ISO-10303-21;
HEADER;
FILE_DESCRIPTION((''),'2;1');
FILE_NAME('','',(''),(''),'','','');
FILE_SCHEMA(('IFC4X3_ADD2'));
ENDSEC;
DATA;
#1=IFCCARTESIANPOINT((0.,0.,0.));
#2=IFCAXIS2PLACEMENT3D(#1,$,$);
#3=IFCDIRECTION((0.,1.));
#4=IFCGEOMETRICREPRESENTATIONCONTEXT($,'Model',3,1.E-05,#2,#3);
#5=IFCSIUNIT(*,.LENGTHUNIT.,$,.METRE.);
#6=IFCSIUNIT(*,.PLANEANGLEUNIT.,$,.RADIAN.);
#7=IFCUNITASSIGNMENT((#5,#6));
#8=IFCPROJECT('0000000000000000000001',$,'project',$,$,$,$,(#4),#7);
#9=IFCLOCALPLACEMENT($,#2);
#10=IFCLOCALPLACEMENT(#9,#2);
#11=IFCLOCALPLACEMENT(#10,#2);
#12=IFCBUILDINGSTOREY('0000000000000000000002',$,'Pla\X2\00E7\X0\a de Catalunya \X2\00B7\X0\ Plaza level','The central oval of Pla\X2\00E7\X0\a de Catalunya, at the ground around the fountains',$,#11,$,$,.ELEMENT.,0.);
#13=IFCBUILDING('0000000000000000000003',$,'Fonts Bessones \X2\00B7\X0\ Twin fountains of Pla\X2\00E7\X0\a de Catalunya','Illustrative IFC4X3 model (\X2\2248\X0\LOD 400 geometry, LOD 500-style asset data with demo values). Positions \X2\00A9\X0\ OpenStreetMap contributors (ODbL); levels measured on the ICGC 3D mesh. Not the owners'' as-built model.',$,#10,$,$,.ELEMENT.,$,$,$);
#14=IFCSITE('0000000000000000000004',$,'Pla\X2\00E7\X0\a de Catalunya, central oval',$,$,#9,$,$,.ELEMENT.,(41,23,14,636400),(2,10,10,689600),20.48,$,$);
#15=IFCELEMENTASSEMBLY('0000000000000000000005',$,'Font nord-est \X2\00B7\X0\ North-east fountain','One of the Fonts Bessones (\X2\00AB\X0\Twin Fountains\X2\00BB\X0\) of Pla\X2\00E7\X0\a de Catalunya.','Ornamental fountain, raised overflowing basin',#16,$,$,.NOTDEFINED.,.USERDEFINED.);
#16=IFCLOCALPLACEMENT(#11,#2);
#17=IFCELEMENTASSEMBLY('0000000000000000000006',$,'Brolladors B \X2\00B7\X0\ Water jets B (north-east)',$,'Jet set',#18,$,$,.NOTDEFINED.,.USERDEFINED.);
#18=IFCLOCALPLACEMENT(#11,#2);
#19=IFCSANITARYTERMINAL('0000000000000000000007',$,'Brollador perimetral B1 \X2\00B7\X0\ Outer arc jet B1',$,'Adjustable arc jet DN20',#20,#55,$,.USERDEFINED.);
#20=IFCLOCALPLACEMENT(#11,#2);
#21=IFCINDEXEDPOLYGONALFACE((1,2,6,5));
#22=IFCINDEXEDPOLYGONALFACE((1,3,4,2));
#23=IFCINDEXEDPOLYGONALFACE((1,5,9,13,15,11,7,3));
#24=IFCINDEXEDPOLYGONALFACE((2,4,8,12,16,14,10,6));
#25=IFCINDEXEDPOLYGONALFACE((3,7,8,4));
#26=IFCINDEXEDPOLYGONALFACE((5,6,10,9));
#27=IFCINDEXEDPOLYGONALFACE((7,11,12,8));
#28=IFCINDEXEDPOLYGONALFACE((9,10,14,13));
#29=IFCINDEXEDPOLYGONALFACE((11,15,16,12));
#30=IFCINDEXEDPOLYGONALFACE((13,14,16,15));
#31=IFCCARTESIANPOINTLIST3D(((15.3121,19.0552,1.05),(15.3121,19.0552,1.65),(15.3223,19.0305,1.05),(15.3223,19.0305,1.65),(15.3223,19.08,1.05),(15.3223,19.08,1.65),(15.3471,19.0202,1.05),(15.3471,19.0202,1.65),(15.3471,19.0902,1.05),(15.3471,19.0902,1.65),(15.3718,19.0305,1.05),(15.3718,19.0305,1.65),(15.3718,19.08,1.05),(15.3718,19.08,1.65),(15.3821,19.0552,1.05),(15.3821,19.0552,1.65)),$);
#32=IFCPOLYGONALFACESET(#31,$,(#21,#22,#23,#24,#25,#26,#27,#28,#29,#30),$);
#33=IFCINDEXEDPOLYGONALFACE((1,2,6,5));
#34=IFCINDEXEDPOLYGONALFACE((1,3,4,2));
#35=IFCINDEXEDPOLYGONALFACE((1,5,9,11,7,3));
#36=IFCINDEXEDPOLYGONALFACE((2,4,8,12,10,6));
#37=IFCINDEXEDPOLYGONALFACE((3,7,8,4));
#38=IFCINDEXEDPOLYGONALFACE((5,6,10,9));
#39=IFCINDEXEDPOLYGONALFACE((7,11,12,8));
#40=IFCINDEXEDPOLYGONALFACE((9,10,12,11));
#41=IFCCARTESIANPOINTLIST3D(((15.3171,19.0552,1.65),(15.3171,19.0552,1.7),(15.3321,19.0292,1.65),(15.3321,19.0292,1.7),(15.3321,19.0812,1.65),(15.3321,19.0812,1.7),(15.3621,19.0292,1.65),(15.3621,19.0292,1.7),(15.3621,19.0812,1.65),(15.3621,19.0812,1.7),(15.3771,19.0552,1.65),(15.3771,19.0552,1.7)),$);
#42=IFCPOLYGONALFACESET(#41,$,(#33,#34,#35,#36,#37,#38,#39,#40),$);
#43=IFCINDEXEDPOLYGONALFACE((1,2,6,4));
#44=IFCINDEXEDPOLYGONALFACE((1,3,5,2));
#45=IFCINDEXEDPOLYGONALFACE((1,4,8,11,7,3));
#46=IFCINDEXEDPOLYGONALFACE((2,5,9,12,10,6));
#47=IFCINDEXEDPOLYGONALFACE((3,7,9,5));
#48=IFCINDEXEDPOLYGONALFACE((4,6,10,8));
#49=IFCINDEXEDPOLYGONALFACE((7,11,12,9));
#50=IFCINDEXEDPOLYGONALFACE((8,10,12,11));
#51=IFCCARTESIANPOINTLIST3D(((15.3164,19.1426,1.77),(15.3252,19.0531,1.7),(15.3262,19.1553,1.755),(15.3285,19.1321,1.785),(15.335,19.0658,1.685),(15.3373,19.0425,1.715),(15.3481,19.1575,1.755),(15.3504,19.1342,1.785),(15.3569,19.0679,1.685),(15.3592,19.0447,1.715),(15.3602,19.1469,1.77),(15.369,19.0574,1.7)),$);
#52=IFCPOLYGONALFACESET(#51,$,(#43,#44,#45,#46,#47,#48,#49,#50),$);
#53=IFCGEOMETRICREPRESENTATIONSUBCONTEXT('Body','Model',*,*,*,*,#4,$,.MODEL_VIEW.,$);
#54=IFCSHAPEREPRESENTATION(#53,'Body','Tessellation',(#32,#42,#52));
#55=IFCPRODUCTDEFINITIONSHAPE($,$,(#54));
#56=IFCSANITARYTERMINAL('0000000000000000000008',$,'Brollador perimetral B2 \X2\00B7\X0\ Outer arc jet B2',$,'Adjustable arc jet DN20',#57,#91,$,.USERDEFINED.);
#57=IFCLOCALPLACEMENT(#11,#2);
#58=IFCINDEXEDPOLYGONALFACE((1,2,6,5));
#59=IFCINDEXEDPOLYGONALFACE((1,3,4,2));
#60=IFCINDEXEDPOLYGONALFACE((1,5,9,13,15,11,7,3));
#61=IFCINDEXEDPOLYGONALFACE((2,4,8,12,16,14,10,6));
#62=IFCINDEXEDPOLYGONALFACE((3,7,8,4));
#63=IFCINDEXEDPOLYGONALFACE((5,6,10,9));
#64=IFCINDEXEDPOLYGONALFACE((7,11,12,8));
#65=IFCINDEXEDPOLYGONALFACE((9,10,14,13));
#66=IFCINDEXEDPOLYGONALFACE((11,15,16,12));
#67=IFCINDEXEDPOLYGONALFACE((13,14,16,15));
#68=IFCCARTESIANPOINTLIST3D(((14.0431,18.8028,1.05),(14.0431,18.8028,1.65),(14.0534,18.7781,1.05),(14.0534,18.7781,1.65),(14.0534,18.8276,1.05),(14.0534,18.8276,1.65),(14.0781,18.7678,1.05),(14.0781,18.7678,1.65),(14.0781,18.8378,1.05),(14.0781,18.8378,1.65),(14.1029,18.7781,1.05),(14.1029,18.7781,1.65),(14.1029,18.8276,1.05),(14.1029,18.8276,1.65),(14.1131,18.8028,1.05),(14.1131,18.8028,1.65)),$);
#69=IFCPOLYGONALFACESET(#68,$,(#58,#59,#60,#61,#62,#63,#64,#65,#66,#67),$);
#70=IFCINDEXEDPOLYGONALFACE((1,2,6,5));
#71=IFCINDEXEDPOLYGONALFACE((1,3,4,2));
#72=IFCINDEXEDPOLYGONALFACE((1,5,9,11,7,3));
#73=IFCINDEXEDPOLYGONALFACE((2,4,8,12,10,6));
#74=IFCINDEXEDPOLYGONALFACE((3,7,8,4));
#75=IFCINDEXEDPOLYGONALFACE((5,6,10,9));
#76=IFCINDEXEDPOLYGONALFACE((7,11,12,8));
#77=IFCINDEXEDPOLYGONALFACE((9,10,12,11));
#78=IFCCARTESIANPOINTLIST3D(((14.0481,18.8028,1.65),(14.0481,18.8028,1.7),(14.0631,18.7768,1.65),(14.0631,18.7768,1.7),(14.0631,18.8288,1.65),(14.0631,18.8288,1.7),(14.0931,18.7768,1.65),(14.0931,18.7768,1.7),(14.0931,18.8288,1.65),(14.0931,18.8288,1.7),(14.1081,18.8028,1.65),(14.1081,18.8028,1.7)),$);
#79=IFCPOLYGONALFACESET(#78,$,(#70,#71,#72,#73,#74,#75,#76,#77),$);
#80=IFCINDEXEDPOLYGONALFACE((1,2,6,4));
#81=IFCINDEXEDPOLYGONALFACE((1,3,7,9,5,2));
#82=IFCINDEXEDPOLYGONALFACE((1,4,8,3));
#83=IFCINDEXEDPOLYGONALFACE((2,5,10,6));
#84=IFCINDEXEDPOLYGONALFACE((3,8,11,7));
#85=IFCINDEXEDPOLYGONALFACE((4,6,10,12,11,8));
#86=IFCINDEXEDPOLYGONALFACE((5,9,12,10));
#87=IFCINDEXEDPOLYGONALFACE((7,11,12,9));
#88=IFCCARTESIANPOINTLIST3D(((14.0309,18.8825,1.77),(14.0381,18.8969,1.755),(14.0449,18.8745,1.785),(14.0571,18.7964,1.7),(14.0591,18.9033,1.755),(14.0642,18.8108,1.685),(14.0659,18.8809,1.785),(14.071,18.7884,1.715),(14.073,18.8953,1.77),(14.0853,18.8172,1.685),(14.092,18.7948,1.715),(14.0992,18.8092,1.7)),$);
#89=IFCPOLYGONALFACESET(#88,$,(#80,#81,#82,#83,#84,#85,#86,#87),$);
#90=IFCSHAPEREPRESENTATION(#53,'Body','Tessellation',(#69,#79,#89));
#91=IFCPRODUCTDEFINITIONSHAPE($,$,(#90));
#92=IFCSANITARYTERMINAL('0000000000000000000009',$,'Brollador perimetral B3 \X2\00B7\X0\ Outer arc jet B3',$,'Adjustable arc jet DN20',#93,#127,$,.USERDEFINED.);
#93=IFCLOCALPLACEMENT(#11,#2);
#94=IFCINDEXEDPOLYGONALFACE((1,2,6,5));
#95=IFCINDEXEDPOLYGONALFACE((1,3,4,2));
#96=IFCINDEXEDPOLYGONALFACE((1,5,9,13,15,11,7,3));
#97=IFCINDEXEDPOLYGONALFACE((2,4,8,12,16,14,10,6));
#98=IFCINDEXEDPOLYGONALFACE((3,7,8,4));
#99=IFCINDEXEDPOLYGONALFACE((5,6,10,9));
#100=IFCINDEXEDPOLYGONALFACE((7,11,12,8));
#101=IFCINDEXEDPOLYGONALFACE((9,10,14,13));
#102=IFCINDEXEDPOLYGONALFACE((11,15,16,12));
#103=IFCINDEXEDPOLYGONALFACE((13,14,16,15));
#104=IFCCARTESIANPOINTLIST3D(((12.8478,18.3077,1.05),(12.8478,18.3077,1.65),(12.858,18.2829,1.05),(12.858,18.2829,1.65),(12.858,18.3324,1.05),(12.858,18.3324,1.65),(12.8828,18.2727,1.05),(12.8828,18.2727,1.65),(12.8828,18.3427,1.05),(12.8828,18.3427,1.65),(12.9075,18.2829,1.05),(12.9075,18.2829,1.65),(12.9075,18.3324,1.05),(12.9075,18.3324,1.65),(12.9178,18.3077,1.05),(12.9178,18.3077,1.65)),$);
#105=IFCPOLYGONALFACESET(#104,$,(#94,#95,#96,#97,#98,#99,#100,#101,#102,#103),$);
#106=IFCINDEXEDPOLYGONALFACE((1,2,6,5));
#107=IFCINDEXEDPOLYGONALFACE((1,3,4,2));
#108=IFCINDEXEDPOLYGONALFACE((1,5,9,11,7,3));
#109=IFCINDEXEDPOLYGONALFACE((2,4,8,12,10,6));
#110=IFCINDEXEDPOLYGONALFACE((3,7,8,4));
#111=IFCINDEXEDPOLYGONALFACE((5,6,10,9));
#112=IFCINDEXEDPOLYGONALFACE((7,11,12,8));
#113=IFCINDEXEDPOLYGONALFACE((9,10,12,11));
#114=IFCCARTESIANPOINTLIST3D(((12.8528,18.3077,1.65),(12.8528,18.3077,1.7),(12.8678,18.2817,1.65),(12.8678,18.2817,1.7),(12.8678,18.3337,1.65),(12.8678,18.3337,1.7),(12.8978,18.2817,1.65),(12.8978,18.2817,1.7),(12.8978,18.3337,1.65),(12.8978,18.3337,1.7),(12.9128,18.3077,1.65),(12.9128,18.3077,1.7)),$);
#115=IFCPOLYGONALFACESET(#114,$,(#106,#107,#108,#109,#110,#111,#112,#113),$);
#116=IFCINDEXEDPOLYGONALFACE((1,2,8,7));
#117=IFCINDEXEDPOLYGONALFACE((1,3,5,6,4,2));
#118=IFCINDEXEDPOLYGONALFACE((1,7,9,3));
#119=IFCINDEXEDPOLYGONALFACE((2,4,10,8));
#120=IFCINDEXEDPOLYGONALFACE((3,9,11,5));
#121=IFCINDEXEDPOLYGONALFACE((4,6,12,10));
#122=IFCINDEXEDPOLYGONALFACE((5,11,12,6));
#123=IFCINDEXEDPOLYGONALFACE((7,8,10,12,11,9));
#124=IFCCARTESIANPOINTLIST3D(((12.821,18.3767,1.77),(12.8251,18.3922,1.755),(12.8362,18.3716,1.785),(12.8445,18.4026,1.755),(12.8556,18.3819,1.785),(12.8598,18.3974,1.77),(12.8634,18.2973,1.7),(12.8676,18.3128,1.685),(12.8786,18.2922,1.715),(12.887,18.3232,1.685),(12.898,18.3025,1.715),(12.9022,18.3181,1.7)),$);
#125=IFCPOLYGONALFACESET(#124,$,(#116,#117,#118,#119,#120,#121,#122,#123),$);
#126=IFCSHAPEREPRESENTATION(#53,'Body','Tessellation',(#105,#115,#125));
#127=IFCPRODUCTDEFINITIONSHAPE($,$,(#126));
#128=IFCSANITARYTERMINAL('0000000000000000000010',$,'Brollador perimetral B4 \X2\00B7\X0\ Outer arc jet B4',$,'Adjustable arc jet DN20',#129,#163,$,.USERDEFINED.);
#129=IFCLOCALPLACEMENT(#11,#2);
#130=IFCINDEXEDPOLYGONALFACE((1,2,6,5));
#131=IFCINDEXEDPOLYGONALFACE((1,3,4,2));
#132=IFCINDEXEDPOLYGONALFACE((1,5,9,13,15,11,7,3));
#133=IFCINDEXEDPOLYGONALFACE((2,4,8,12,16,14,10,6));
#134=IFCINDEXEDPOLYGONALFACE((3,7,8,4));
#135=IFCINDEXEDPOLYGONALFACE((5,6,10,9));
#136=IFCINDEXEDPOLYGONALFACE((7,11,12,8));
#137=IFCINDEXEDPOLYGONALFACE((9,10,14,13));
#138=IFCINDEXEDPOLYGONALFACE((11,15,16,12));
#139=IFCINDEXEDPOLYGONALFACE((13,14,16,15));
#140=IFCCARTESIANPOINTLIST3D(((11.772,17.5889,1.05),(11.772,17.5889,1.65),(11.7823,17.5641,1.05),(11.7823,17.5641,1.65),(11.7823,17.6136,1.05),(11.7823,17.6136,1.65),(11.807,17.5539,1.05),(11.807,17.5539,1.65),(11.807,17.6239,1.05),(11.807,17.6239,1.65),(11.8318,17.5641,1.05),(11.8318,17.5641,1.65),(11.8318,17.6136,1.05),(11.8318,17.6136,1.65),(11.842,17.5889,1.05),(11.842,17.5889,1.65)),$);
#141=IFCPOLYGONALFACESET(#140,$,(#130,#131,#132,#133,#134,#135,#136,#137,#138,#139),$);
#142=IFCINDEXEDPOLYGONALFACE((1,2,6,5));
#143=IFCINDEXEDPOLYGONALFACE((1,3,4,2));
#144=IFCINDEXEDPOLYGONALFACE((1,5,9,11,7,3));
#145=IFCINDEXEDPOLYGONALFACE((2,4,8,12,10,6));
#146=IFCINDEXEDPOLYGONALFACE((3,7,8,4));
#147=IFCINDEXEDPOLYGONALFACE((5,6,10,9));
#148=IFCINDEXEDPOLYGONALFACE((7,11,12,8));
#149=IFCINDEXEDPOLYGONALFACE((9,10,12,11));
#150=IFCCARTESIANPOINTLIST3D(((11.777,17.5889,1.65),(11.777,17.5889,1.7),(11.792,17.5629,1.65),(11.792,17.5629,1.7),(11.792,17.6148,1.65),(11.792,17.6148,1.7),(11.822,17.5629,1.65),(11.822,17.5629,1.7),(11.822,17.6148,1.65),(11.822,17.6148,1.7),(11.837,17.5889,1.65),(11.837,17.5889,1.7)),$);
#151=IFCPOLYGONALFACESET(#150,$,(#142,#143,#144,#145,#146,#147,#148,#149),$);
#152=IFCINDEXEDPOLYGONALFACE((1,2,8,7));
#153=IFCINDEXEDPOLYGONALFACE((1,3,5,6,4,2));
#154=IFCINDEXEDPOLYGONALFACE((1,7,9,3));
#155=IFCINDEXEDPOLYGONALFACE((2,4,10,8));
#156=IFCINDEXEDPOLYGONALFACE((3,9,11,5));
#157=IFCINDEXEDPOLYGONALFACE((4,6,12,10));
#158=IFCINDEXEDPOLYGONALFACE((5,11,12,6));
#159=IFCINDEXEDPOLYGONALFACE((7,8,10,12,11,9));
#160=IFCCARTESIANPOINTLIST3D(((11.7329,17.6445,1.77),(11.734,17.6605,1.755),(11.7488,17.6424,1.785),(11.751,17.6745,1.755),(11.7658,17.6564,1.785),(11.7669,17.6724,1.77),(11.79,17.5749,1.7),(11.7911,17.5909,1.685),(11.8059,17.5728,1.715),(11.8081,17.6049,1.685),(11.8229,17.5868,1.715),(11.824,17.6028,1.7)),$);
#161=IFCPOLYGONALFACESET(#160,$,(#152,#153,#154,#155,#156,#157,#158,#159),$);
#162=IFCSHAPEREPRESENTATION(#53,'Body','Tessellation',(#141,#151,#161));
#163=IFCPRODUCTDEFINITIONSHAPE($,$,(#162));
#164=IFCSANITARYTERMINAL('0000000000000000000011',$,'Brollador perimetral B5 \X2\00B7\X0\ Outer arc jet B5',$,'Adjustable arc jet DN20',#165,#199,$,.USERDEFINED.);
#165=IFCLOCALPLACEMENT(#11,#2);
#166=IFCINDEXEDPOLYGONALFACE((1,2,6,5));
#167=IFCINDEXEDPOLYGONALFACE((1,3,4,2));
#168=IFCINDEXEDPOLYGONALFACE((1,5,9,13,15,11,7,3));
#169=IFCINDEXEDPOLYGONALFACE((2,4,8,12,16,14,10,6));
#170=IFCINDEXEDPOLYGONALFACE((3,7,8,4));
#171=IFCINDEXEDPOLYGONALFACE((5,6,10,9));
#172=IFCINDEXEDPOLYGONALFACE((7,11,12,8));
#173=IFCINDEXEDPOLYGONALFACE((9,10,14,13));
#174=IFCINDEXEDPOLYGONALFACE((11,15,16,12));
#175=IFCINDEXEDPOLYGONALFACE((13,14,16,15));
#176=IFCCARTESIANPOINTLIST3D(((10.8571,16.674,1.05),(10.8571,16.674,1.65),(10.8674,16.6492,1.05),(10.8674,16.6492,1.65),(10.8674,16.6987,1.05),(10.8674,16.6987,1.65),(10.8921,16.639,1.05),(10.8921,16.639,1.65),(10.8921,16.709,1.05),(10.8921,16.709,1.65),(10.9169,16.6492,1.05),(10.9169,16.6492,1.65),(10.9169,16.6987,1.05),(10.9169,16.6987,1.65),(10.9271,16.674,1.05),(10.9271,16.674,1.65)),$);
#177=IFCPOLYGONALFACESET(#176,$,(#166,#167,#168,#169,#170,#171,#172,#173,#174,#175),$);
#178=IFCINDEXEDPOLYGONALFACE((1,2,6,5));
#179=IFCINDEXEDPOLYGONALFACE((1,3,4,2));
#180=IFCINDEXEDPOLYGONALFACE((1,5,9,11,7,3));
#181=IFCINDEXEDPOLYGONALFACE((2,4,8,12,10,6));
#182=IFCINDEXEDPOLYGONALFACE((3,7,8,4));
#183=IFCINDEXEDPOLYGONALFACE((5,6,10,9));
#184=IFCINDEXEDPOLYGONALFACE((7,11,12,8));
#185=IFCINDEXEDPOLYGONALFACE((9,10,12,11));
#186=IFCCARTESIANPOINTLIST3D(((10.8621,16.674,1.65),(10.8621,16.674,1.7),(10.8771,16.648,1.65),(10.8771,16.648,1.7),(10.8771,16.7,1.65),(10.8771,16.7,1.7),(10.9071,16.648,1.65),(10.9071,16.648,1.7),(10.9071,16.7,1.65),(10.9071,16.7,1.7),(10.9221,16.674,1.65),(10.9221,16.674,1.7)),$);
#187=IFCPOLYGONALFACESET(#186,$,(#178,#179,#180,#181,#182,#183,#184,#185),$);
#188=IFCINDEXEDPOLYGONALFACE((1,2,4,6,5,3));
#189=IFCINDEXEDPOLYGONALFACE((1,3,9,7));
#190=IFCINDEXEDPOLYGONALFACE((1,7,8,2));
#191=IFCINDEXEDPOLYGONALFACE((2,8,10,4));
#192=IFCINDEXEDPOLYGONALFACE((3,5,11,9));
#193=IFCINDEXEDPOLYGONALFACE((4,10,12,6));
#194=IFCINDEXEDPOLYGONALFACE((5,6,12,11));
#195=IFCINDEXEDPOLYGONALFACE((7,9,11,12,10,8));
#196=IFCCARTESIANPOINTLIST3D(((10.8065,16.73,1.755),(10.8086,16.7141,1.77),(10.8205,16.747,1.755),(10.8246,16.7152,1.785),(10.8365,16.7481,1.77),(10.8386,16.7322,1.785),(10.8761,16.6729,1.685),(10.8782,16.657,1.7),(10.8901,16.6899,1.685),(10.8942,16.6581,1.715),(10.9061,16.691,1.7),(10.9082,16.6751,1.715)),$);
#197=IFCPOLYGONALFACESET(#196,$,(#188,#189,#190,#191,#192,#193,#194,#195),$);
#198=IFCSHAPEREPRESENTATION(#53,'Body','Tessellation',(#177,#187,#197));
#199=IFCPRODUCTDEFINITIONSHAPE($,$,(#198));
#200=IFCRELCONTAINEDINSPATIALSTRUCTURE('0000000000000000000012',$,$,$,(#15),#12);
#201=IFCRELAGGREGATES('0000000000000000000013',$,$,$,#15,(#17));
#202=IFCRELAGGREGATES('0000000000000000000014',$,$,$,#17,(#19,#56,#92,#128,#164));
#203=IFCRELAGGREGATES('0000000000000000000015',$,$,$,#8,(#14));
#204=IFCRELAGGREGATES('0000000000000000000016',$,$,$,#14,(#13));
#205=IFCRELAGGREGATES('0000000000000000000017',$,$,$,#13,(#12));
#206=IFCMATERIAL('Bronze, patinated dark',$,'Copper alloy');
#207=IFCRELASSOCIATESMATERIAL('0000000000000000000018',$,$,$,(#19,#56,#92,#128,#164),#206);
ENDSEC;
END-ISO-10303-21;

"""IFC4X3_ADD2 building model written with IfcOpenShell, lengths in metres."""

from ifc_helpers import new_model, si_unit, direction, frame, origin, place, context, subcontext, project, spatial, polyline, outline, extrude, material, element, aggregate, save


model = new_model("IFC4X3_ADD2")

# Units and contexts
model_context = context("Model", 3, precision=1e-05, world=origin(), true_north=direction((0.0, 1.0)))
body_context = subcontext(model_context, "Body", "Model", "MODEL_VIEW")
ifc_project = project(units=[si_unit("LENGTHUNIT", "METRE"), si_unit("PLANEANGLEUNIT", "RADIAN")], contexts=[model_context])

# Site, building, storey
site_placement = place(None, origin())
site = spatial("IfcSite", under=ifc_project, at=site_placement, Name="Plaça de Catalunya, central oval", CompositionType="ELEMENT", RefLatitude=(41, 23, 14, 636400), RefLongitude=(2, 10, 10, 689600), RefElevation=20.48)
building_placement = place(site_placement, origin())
building = spatial("IfcBuilding", under=site, at=building_placement, Name="Fonts Bessones · Twin fountains of Plaça de Catalunya", Description="Illustrative IFC4X3 model (≈LOD 400 geometry, LOD 500-style asset data with demo values). Positions © OpenStreetMap contributors (ODbL); levels measured on the ICGC 3D mesh. Not the owners' as-built model.", CompositionType="ELEMENT")
storey_placement = place(building_placement, origin())
storey = spatial("IfcBuildingStorey", under=building, at=storey_placement, Name="Plaça de Catalunya · Plaza level", Description="The central oval of Plaça de Catalunya, at the ground around the fountains", CompositionType="ELEMENT", Elevation=0.0)

# Element assemblies, sanitary terminals
assembly_1_placement = place(building_placement, origin())
assembly_1 = element("IfcElementAssembly", 1, at=assembly_1_placement, inside=storey, Name="Font nord-est · North-east fountain", Description="One of the Fonts Bessones («Twin Fountains») of Plaça de Catalunya.", ObjectType="Ornamental fountain, raised overflowing basin", AssemblyPlace="NOTDEFINED", PredefinedType="USERDEFINED")
assembly_2_placement = place(building_placement, origin())
assembly_2 = element("IfcElementAssembly", 2, at=assembly_2_placement, Name="Brolladors B · Water jets B (north-east)", ObjectType="Jet set", AssemblyPlace="NOTDEFINED", PredefinedType="USERDEFINED")
aggregate(assembly_1, [assembly_2])
ifc_material_1 = material(Name="Bronze, patinated dark", Category="Copper alloy")
sanitary_terminal_1_placement = place(building_placement, origin())
sanitary_terminal_1 = element("IfcSanitaryTerminal", 3, at=sanitary_terminal_1_placement, material=ifc_material_1, Name="Brollador perimetral B1 · Outer arc jet B1", ObjectType="Adjustable arc jet DN20", PredefinedType="USERDEFINED", context=body_context, shape_type="SweptSolid", body=[
    extrude(outline(polyline([(15.3821, 19.0552), (15.3718, 19.08), (15.3471, 19.0902), (15.3223, 19.08), (15.3121, 19.0552), (15.3223, 19.0305), (15.3471, 19.0202), (15.3718, 19.0305), (15.3821, 19.0552)])), frame((0.0, 0.0, 1.05)), (0.0, 0.0, 1.0), 0.6),
    extrude(outline(polyline([(15.3771, 19.0552), (15.3621, 19.0812), (15.3321, 19.0812), (15.3171, 19.0552), (15.3321, 19.0292), (15.3621, 19.0292), (15.3771, 19.0552)])), frame((0.0, 0.0, 1.65)), (0.0, 0.0, 1.0), 0.05),
    extrude(outline(polyline([(0.022, 0.0), (0.011, 0.0191), (-0.011, 0.0191), (-0.022, 0.0), (-0.011, -0.0191), (0.011, -0.0191), (0.022, 0.0)])), frame((15.3471, 19.0552, 1.7), z_axis=(-0.07737, 0.785551, 0.613941), x_axis=(0.995185, 0.098017, 0.0)), (0.0, 0.0, 1.0), 0.114),
])
sanitary_terminal_2_placement = place(building_placement, origin())
sanitary_terminal_2 = element("IfcSanitaryTerminal", 4, at=sanitary_terminal_2_placement, material=ifc_material_1, Name="Brollador perimetral B2 · Outer arc jet B2", ObjectType="Adjustable arc jet DN20", PredefinedType="USERDEFINED", context=body_context, shape_type="SweptSolid", body=[
    extrude(outline(polyline([(14.1131, 18.8028), (14.1029, 18.8276), (14.0781, 18.8378), (14.0534, 18.8276), (14.0431, 18.8028), (14.0534, 18.7781), (14.0781, 18.7678), (14.1029, 18.7781), (14.1131, 18.8028)])), frame((0.0, 0.0, 1.05)), (0.0, 0.0, 1.0), 0.6),
    extrude(outline(polyline([(14.1081, 18.8028), (14.0931, 18.8288), (14.0631, 18.8288), (14.0481, 18.8028), (14.0631, 18.7768), (14.0931, 18.7768), (14.1081, 18.8028)])), frame((0.0, 0.0, 1.65)), (0.0, 0.0, 1.0), 0.05),
    extrude(outline(polyline([(0.022, 0.0), (0.011, 0.0191), (-0.011, 0.0191), (-0.022, 0.0), (-0.011, -0.0191), (0.011, -0.0191), (0.022, 0.0)])), frame((14.0781, 18.8028, 1.7), z_axis=(-0.229137, 0.755363, 0.613941), x_axis=(0.95694, 0.290285, 0.0)), (0.0, 0.0, 1.0), 0.114),
])
sanitary_terminal_3_placement = place(building_placement, origin())
sanitary_terminal_3 = element("IfcSanitaryTerminal", 5, at=sanitary_terminal_3_placement, material=ifc_material_1, Name="Brollador perimetral B3 · Outer arc jet B3", ObjectType="Adjustable arc jet DN20", PredefinedType="USERDEFINED", context=body_context, shape_type="SweptSolid", body=[
    extrude(outline(polyline([(12.9178, 18.3077), (12.9075, 18.3324), (12.8828, 18.3427), (12.858, 18.3324), (12.8478, 18.3077), (12.858, 18.2829), (12.8828, 18.2727), (12.9075, 18.2829), (12.9178, 18.3077)])), frame((0.0, 0.0, 1.05)), (0.0, 0.0, 1.0), 0.6),
    extrude(outline(polyline([(12.9128, 18.3077), (12.8978, 18.3337), (12.8678, 18.3337), (12.8528, 18.3077), (12.8678, 18.2817), (12.8978, 18.2817), (12.9128, 18.3077)])), frame((0.0, 0.0, 1.65)), (0.0, 0.0, 1.0), 0.05),
    extrude(outline(polyline([(0.022, 0.0), (0.011, 0.0191), (-0.011, 0.0191), (-0.022, 0.0), (-0.011, -0.0191), (0.011, -0.0191), (0.022, 0.0)])), frame((12.8828, 18.3077, 1.7), z_axis=(-0.372098, 0.696147, 0.613941), x_axis=(0.881921, 0.471397, 0.0)), (0.0, 0.0, 1.0), 0.114),
])
sanitary_terminal_4_placement = place(building_placement, origin())
sanitary_terminal_4 = element("IfcSanitaryTerminal", 6, at=sanitary_terminal_4_placement, material=ifc_material_1, Name="Brollador perimetral B4 · Outer arc jet B4", ObjectType="Adjustable arc jet DN20", PredefinedType="USERDEFINED", context=body_context, shape_type="SweptSolid", body=[
    extrude(outline(polyline([(11.842, 17.5889), (11.8318, 17.6136), (11.807, 17.6239), (11.7823, 17.6136), (11.772, 17.5889), (11.7823, 17.5641), (11.807, 17.5539), (11.8318, 17.5641), (11.842, 17.5889)])), frame((0.0, 0.0, 1.05)), (0.0, 0.0, 1.0), 0.6),
    extrude(outline(polyline([(11.837, 17.5889), (11.822, 17.6148), (11.792, 17.6148), (11.777, 17.5889), (11.792, 17.5629), (11.822, 17.5629), (11.837, 17.5889)])), frame((0.0, 0.0, 1.65)), (0.0, 0.0, 1.0), 0.05),
    extrude(outline(polyline([(0.022, 0.0), (0.011, 0.0191), (-0.011, 0.0191), (-0.022, 0.0), (-0.011, -0.0191), (0.011, -0.0191), (0.022, 0.0)])), frame((11.807, 17.5889, 1.7), z_axis=(-0.50076, 0.610178, 0.613941), x_axis=(0.77301, 0.634393, 0.0)), (0.0, 0.0, 1.0), 0.114),
])
sanitary_terminal_5_placement = place(building_placement, origin())
sanitary_terminal_5 = element("IfcSanitaryTerminal", 7, at=sanitary_terminal_5_placement, material=ifc_material_1, Name="Brollador perimetral B5 · Outer arc jet B5", ObjectType="Adjustable arc jet DN20", PredefinedType="USERDEFINED", context=body_context, shape_type="SweptSolid", body=[
    extrude(outline(polyline([(10.9271, 16.674), (10.9169, 16.6987), (10.8921, 16.709), (10.8674, 16.6987), (10.8571, 16.674), (10.8674, 16.6492), (10.8921, 16.639), (10.9169, 16.6492), (10.9271, 16.674)])), frame((0.0, 0.0, 1.05)), (0.0, 0.0, 1.0), 0.6),
    extrude(outline(polyline([(10.9221, 16.674), (10.9071, 16.7), (10.8771, 16.7), (10.8621, 16.674), (10.8771, 16.648), (10.9071, 16.648), (10.9221, 16.674)])), frame((0.0, 0.0, 1.65)), (0.0, 0.0, 1.0), 0.05),
    extrude(outline(polyline([(0.022, 0.0), (0.011, 0.0191), (-0.011, 0.0191), (-0.022, 0.0), (-0.011, -0.0191), (0.011, -0.0191), (0.022, 0.0)])), frame((10.8921, 16.674, 1.7), z_axis=(-0.610178, 0.50076, 0.613941), x_axis=(0.634393, 0.77301, 0.0)), (0.0, 0.0, 1.0), 0.114),
])
aggregate(assembly_2, [sanitary_terminal_1, sanitary_terminal_2, sanitary_terminal_3, sanitary_terminal_4, sanitary_terminal_5])

save(model, "model.ifc")
